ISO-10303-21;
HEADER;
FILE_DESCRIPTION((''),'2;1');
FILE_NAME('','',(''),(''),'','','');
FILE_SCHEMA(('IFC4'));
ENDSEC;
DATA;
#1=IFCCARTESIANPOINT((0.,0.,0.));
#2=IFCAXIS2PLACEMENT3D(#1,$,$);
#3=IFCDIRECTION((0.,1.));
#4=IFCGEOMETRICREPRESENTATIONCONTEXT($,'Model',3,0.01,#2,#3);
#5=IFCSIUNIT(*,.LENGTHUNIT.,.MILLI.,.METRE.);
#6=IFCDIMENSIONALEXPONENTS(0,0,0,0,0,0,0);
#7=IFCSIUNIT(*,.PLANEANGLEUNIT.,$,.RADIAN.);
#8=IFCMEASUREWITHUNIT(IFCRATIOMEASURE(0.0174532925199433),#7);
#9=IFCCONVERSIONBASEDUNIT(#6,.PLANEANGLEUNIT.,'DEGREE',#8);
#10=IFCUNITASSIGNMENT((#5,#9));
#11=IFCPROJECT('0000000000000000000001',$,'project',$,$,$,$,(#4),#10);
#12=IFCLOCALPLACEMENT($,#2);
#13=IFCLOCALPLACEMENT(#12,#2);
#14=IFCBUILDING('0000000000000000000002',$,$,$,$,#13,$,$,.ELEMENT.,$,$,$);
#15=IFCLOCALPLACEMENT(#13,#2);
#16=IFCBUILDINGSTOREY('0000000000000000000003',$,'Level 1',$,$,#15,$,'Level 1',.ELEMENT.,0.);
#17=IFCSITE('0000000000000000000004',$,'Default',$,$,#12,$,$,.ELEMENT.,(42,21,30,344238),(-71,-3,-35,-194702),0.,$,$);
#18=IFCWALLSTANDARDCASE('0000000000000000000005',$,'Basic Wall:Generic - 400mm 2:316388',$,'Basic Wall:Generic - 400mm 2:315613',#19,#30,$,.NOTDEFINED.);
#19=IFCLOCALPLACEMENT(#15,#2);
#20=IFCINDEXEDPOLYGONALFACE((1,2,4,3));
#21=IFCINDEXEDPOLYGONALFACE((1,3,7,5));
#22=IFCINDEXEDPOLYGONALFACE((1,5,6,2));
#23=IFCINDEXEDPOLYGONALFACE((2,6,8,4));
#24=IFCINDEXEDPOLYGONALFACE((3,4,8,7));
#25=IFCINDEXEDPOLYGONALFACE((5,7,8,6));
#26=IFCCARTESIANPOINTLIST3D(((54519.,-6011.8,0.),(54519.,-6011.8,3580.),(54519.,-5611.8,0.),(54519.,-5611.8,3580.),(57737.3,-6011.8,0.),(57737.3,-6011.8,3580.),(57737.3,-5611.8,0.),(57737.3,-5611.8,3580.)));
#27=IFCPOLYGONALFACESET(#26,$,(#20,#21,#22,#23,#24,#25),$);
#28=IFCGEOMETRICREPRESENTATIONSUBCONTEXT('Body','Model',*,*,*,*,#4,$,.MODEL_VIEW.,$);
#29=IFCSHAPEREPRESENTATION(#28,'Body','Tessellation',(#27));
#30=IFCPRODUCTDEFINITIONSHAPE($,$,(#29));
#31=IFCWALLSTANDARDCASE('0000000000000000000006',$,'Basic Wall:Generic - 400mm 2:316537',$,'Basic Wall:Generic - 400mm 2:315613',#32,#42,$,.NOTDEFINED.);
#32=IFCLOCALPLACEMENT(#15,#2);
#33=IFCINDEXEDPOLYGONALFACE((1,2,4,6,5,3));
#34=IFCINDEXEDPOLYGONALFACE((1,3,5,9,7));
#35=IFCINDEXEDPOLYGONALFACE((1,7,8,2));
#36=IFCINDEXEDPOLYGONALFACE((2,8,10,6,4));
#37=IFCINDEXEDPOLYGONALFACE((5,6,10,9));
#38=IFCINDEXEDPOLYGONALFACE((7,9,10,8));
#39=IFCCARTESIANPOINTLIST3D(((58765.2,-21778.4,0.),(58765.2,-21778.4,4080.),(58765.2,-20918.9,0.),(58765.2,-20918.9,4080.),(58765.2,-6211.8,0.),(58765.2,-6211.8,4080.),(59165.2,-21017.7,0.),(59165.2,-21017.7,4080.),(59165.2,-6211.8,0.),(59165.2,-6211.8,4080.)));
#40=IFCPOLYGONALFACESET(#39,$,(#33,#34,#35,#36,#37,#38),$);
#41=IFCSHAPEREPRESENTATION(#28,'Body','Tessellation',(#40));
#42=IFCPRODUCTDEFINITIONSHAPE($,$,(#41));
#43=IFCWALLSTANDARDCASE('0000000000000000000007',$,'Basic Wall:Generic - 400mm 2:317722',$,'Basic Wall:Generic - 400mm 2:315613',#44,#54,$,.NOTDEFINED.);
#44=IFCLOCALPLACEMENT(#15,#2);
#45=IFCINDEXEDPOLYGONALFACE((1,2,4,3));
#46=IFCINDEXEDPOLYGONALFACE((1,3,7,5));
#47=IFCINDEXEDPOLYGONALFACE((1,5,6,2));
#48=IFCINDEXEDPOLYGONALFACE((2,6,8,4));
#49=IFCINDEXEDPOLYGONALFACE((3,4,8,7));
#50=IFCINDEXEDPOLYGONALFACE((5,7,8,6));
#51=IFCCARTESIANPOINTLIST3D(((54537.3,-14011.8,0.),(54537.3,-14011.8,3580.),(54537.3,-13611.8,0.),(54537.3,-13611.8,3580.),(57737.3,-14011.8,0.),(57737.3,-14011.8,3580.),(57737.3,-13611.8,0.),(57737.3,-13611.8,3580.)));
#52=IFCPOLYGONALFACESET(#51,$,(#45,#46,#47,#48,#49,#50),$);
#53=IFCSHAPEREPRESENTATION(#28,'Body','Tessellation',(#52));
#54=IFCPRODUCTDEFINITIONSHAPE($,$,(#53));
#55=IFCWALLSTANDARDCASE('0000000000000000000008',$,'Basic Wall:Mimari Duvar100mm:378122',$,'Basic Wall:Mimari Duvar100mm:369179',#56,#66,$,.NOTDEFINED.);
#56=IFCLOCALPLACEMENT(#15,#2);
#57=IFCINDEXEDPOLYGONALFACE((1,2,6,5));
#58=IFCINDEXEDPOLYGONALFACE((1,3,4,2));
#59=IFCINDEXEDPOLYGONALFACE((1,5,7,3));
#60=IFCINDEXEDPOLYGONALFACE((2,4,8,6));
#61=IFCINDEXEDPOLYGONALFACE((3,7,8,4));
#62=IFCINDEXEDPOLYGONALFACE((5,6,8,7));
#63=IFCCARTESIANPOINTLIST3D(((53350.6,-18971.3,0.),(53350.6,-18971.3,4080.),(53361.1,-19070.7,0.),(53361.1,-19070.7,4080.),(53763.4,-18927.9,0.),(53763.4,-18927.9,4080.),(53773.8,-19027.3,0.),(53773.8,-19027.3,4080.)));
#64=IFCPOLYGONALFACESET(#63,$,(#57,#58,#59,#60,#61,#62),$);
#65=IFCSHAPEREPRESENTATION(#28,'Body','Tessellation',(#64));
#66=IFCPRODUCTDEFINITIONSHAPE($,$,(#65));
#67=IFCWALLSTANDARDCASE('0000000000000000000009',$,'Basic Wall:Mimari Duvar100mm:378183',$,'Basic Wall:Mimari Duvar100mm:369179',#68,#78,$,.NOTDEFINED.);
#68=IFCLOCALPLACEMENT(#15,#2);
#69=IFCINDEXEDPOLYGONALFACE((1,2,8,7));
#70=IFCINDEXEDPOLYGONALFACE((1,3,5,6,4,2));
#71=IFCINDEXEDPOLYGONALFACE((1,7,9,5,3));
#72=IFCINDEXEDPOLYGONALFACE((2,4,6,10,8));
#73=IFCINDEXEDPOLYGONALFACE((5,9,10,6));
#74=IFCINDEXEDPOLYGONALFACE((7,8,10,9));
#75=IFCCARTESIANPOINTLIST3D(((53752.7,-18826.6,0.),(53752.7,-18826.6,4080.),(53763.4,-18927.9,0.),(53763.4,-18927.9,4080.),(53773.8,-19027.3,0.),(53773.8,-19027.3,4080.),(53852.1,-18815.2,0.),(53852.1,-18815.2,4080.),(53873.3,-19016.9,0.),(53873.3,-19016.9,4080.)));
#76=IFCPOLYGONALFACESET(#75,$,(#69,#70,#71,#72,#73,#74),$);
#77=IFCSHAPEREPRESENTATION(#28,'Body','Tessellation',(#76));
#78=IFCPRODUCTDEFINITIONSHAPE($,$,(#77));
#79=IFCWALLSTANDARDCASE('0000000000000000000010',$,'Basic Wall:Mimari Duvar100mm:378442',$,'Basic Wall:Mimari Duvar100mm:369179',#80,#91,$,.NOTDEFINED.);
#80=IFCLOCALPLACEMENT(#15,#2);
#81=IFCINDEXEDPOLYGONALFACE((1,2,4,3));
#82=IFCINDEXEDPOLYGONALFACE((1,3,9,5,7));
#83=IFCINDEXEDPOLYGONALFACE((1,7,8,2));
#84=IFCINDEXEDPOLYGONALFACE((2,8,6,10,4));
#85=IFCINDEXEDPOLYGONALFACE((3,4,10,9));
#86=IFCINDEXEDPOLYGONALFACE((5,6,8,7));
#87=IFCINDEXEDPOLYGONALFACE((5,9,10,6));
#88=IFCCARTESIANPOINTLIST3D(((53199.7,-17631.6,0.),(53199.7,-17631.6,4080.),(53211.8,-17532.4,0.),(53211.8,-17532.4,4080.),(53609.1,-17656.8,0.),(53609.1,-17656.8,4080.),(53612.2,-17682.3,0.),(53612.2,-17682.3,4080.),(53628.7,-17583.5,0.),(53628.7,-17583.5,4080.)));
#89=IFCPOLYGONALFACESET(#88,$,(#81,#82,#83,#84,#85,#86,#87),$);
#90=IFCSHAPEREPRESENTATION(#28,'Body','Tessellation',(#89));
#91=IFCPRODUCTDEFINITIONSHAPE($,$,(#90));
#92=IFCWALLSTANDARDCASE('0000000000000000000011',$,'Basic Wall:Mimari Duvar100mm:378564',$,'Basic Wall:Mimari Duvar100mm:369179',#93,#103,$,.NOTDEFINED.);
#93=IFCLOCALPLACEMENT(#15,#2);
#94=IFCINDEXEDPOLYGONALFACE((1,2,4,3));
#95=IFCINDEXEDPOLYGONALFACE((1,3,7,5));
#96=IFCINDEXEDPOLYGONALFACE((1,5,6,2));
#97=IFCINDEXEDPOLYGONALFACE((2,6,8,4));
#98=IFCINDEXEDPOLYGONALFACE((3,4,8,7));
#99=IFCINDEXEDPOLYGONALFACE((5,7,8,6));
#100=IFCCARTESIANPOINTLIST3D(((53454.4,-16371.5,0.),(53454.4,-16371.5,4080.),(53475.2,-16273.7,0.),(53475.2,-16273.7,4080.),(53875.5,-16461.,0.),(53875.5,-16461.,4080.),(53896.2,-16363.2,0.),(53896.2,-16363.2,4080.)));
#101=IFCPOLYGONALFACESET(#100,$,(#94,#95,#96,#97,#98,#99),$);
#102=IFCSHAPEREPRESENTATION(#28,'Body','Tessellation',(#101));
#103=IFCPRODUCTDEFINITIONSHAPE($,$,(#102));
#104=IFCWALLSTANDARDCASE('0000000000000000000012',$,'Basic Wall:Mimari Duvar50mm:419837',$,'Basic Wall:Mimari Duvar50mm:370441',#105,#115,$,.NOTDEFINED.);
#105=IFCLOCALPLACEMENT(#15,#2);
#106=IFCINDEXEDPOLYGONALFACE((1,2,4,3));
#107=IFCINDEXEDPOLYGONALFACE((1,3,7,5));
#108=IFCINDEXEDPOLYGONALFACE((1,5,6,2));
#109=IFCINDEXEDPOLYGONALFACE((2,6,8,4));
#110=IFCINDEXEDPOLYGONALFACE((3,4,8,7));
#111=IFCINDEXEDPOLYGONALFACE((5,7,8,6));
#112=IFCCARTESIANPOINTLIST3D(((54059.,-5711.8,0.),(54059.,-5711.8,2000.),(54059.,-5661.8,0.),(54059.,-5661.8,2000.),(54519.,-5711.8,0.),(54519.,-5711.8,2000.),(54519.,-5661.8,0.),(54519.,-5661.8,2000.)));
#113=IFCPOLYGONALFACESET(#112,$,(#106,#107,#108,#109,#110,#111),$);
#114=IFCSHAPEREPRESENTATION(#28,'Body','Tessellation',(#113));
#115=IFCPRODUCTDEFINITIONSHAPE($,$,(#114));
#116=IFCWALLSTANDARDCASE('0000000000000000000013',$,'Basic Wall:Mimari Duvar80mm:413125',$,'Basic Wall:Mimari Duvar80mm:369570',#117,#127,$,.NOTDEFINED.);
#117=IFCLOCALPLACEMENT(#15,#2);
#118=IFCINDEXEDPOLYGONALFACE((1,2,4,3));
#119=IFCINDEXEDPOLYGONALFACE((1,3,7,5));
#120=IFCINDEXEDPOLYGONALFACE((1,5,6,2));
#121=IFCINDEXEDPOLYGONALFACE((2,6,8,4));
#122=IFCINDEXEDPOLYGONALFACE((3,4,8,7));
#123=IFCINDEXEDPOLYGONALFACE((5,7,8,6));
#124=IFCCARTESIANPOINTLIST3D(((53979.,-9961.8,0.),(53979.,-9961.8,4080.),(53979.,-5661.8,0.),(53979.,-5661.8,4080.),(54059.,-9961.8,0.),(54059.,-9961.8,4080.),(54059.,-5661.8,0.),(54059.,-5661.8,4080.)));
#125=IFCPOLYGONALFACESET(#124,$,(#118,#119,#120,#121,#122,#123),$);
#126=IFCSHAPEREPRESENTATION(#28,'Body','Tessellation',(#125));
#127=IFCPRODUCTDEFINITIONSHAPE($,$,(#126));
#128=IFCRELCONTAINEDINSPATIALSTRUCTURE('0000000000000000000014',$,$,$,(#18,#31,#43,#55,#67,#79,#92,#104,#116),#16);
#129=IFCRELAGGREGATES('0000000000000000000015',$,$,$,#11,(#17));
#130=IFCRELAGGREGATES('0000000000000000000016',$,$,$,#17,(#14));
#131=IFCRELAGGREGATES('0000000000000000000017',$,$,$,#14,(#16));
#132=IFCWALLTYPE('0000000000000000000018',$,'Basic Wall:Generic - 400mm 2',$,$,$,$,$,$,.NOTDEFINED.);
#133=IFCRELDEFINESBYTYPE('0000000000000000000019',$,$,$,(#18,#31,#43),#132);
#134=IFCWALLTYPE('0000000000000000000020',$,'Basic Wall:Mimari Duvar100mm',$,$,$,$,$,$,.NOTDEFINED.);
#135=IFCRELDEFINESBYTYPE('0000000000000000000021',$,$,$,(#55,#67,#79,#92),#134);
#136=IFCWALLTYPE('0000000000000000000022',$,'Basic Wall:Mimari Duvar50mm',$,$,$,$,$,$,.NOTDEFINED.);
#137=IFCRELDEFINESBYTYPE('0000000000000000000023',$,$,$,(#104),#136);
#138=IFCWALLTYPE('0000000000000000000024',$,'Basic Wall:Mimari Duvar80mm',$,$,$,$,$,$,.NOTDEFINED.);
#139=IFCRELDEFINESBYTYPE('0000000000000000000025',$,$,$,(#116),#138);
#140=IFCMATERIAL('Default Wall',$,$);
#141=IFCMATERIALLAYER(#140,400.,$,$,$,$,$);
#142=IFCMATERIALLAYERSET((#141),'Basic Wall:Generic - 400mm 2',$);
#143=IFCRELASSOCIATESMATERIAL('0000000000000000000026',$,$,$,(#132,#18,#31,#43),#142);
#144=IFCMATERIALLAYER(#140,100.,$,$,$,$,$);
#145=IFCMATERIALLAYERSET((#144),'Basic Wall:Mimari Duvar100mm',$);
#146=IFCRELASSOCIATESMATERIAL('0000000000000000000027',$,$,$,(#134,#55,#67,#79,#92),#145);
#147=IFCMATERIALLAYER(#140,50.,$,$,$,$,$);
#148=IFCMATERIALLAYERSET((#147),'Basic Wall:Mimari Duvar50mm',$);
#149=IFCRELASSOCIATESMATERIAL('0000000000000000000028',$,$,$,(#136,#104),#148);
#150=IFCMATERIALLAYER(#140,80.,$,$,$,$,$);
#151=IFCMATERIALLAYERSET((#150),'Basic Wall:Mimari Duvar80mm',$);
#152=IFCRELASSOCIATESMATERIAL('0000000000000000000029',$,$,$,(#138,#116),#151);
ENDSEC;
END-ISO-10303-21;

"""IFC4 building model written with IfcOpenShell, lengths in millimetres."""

from ifc_helpers import new_model, entity, si_unit, converted_unit, direction, frame, frame_2d, origin, place, context, subcontext, project, spatial, polyline, rectangle, outline, extrude, material, layer, layer_set, layer_usage, type_object, element, save


model = new_model("IFC4")

# Units and contexts
model_context = context("Model", 3, precision=0.01, world=origin(), true_north=direction((0.0, 1.0)))
body_context = subcontext(model_context, "Body", "Model", "MODEL_VIEW")
ifc_project = project(units=[si_unit("LENGTHUNIT", "METRE", prefix="MILLI"), converted_unit("PLANEANGLEUNIT", "DEGREE", entity("IfcRatioMeasure", 0.0174532925199433), si_unit("PLANEANGLEUNIT", "RADIAN"), dimensions=[0, 0, 0, 0, 0, 0, 0])], contexts=[model_context])

# Site, building, storey
site_placement = place(None, origin())
site = spatial("IfcSite", under=ifc_project, at=site_placement, Name="Default", CompositionType="ELEMENT", RefLatitude=(42, 21, 30, 344238), RefLongitude=(-71, -3, -35, -194702), RefElevation=0.0)
building_placement = place(site_placement, origin())
building = spatial("IfcBuilding", under=site, at=building_placement, CompositionType="ELEMENT")
storey_placement = place(building_placement, origin())
storey = spatial("IfcBuildingStorey", under=building, at=storey_placement, Name="Level 1", LongName="Level 1", CompositionType="ELEMENT", Elevation=0.0)

# Walls
ifc_material_1 = material(Name="Default Wall")
ifc_layer_1 = layer(ifc_material_1, 400.0)
ifc_layer_set_1 = layer_set([ifc_layer_1], Name="Basic Wall:Generic - 400mm 2")
ifc_layer_usage_1 = layer_usage(ifc_layer_set_1, "AXIS2", "NEGATIVE", 200.0)
wall_type_1 = type_object("IfcWallType", Name="Basic Wall:Generic - 400mm 2", PredefinedType="NOTDEFINED", material=ifc_layer_set_1)
wall_1_placement = place(storey_placement, frame((54519.0, -5811.8, 0.0)))
element("IfcWallStandardCase", 1, at=wall_1_placement, inside=storey, type_object=wall_type_1, material=ifc_layer_usage_1, Name="Basic Wall:Generic - 400mm 2:316388", ObjectType="Basic Wall:Generic - 400mm 2:315613", PredefinedType="NOTDEFINED", context=body_context, shape_type="SweptSolid", body=[
    extrude(rectangle(XDim=3218.3, YDim=400.0, at=frame_2d((1609.1, 0.0), x_axis=(-1.0, 0.0))), origin(), (0.0, 0.0, 1.0), 3580.0),
])
ifc_layer_usage_2 = layer_usage(ifc_layer_set_1, "AXIS2", "NEGATIVE", 200.0)
wall_2_placement = place(storey_placement, frame((58965.2, -6211.8, 0.0), z_axis=(0.0, 0.0, 1.0), x_axis=(0.0, -1.0, 0.0)))
element("IfcWallStandardCase", 2, at=wall_2_placement, inside=storey, type_object=wall_type_1, material=ifc_layer_usage_2, Name="Basic Wall:Generic - 400mm 2:316537", ObjectType="Basic Wall:Generic - 400mm 2:315613", PredefinedType="NOTDEFINED", context=body_context, shape_type="SweptSolid", body=[
    extrude(outline(polyline([(15566.6, -200.0), (14805.9, 200.0), (0.0, 200.0), (0.0, -200.0), (14707.2, -200.0), (15566.6, -200.0)])), origin(), (0.0, 0.0, 1.0), 4080.0),
])
ifc_layer_usage_3 = layer_usage(ifc_layer_set_1, "AXIS2", "NEGATIVE", 200.0)
wall_3_placement = place(storey_placement, frame((54537.3, -13811.8, 0.0)))
element("IfcWallStandardCase", 3, at=wall_3_placement, inside=storey, type_object=wall_type_1, material=ifc_layer_usage_3, Name="Basic Wall:Generic - 400mm 2:317722", ObjectType="Basic Wall:Generic - 400mm 2:315613", PredefinedType="NOTDEFINED", context=body_context, shape_type="SweptSolid", body=[
    extrude(rectangle(XDim=3200.0, YDim=400.0, at=frame_2d((1600.0, 0.0), x_axis=(-1.0, 0.0))), origin(), (0.0, 0.0, 1.0), 3580.0),
])
ifc_layer_2 = layer(ifc_material_1, 100.0)
ifc_layer_set_2 = layer_set([ifc_layer_2], Name="Basic Wall:Mimari Duvar100mm")
ifc_layer_usage_4 = layer_usage(ifc_layer_set_2, "AXIS2", "NEGATIVE", 50.0)
wall_type_2 = type_object("IfcWallType", Name="Basic Wall:Mimari Duvar100mm", PredefinedType="NOTDEFINED", material=ifc_layer_set_2)
wall_4_placement = place(storey_placement, frame((53355.9, -19021.0, 0.0), z_axis=(0.0, 0.0, 1.0), x_axis=(0.994522, 0.104528, 0.0)))
element("IfcWallStandardCase", 4, at=wall_4_placement, inside=storey, type_object=wall_type_2, material=ifc_layer_usage_4, Name="Basic Wall:Mimari Duvar100mm:378122", ObjectType="Basic Wall:Mimari Duvar100mm:369179", PredefinedType="NOTDEFINED", context=body_context, shape_type="SweptSolid", body=[
    extrude(rectangle(XDim=415.0, YDim=100.0, at=frame_2d((207.5, 0.0), x_axis=(-1.0, 0.0))), origin(), (0.0, 0.0, 1.0), 4080.0),
])
ifc_layer_usage_5 = layer_usage(ifc_layer_set_2, "AXIS2", "NEGATIVE", 50.0)
wall_5_placement = place(storey_placement, frame((53823.5, -19022.1, 0.0), z_axis=(0.0, 0.0, 1.0), x_axis=(-0.104528, 0.994522, 0.0)))
element("IfcWallStandardCase", 5, at=wall_5_placement, inside=storey, type_object=wall_type_2, material=ifc_layer_usage_5, Name="Basic Wall:Mimari Duvar100mm:378183", ObjectType="Basic Wall:Mimari Duvar100mm:369179", PredefinedType="NOTDEFINED", context=body_context, shape_type="SweptSolid", body=[
    extrude(outline(polyline([(202.8, -50.0), (201.9, 50.0), (100.0, 50.0), (0.0, 50.0), (0.0, -50.0), (202.8, -50.0)])), origin(), (0.0, 0.0, 1.0), 4080.0),
])
ifc_layer_usage_6 = layer_usage(ifc_layer_set_2, "AXIS2", "NEGATIVE", 50.0)
wall_6_placement = place(storey_placement, frame((53622.6, -17633.2, 0.0), z_axis=(0.0, 0.0, 1.0), x_axis=(-0.992546, 0.121869, 0.0)))
element("IfcWallStandardCase", 6, at=wall_6_placement, inside=storey, type_object=wall_type_2, material=ifc_layer_usage_6, Name="Basic Wall:Mimari Duvar100mm:378442", ObjectType="Basic Wall:Mimari Duvar100mm:369179", PredefinedType="NOTDEFINED", context=body_context, shape_type="SweptSolid", body=[
    extrude(outline(polyline([(420.0, -50.0), (420.0, 50.0), (4.3, 50.0), (10.6, 25.1), (0.0, -50.0), (420.0, -50.0)])), origin(), (0.0, 0.0, 1.0), 4080.0),
])
ifc_layer_usage_7 = layer_usage(ifc_layer_set_2, "AXIS2", "NEGATIVE", 50.0)
wall_7_placement = place(storey_placement, frame((53885.8, -16412.1, 0.0), z_axis=(0.0, 0.0, 1.0), x_axis=(-0.978148, 0.207912, 0.0)))
element("IfcWallStandardCase", 7, at=wall_7_placement, inside=storey, type_object=wall_type_2, material=ifc_layer_usage_7, Name="Basic Wall:Mimari Duvar100mm:378564", ObjectType="Basic Wall:Mimari Duvar100mm:369179", PredefinedType="NOTDEFINED", context=body_context, shape_type="SweptSolid", body=[
    extrude(rectangle(XDim=430.4, YDim=100.0, at=frame_2d((215.2, 0.0), x_axis=(-1.0, 0.0))), origin(), (0.0, 0.0, 1.0), 4080.0),
])
ifc_layer_3 = layer(ifc_material_1, 50.0)
ifc_layer_set_3 = layer_set([ifc_layer_3], Name="Basic Wall:Mimari Duvar50mm")
ifc_layer_usage_8 = layer_usage(ifc_layer_set_3, "AXIS2", "NEGATIVE", 25.0)
wall_type_3 = type_object("IfcWallType", Name="Basic Wall:Mimari Duvar50mm", PredefinedType="NOTDEFINED", material=ifc_layer_set_3)
wall_8_placement = place(storey_placement, frame((54059.0, -5686.8, 0.0)))
element("IfcWallStandardCase", 8, at=wall_8_placement, inside=storey, type_object=wall_type_3, material=ifc_layer_usage_8, Name="Basic Wall:Mimari Duvar50mm:419837", ObjectType="Basic Wall:Mimari Duvar50mm:370441", PredefinedType="NOTDEFINED", context=body_context, shape_type="SweptSolid", body=[
    extrude(rectangle(XDim=460.0, YDim=50.0, at=frame_2d((230.0, 0.0), x_axis=(-1.0, 0.0))), origin(), (0.0, 0.0, 1.0), 2000.0),
])
ifc_layer_4 = layer(ifc_material_1, 80.0)
ifc_layer_set_4 = layer_set([ifc_layer_4], Name="Basic Wall:Mimari Duvar80mm")
ifc_layer_usage_9 = layer_usage(ifc_layer_set_4, "AXIS2", "NEGATIVE", 40.0)
wall_type_4 = type_object("IfcWallType", Name="Basic Wall:Mimari Duvar80mm", PredefinedType="NOTDEFINED", material=ifc_layer_set_4)
wall_9_placement = place(storey_placement, frame((54019.0, -9961.8, 0.0), z_axis=(0.0, 0.0, 1.0), x_axis=(0.0, 1.0, 0.0)))
element("IfcWallStandardCase", 9, at=wall_9_placement, inside=storey, type_object=wall_type_4, material=ifc_layer_usage_9, Name="Basic Wall:Mimari Duvar80mm:413125", ObjectType="Basic Wall:Mimari Duvar80mm:369570", PredefinedType="NOTDEFINED", context=body_context, shape_type="SweptSolid", body=[
    extrude(rectangle(XDim=4300.0, YDim=80.0, at=frame_2d((2150.0, 0.0), x_axis=(-1.0, 0.0))), origin(), (0.0, 0.0, 1.0), 4080.0),
])

save(model, "model.ifc")
